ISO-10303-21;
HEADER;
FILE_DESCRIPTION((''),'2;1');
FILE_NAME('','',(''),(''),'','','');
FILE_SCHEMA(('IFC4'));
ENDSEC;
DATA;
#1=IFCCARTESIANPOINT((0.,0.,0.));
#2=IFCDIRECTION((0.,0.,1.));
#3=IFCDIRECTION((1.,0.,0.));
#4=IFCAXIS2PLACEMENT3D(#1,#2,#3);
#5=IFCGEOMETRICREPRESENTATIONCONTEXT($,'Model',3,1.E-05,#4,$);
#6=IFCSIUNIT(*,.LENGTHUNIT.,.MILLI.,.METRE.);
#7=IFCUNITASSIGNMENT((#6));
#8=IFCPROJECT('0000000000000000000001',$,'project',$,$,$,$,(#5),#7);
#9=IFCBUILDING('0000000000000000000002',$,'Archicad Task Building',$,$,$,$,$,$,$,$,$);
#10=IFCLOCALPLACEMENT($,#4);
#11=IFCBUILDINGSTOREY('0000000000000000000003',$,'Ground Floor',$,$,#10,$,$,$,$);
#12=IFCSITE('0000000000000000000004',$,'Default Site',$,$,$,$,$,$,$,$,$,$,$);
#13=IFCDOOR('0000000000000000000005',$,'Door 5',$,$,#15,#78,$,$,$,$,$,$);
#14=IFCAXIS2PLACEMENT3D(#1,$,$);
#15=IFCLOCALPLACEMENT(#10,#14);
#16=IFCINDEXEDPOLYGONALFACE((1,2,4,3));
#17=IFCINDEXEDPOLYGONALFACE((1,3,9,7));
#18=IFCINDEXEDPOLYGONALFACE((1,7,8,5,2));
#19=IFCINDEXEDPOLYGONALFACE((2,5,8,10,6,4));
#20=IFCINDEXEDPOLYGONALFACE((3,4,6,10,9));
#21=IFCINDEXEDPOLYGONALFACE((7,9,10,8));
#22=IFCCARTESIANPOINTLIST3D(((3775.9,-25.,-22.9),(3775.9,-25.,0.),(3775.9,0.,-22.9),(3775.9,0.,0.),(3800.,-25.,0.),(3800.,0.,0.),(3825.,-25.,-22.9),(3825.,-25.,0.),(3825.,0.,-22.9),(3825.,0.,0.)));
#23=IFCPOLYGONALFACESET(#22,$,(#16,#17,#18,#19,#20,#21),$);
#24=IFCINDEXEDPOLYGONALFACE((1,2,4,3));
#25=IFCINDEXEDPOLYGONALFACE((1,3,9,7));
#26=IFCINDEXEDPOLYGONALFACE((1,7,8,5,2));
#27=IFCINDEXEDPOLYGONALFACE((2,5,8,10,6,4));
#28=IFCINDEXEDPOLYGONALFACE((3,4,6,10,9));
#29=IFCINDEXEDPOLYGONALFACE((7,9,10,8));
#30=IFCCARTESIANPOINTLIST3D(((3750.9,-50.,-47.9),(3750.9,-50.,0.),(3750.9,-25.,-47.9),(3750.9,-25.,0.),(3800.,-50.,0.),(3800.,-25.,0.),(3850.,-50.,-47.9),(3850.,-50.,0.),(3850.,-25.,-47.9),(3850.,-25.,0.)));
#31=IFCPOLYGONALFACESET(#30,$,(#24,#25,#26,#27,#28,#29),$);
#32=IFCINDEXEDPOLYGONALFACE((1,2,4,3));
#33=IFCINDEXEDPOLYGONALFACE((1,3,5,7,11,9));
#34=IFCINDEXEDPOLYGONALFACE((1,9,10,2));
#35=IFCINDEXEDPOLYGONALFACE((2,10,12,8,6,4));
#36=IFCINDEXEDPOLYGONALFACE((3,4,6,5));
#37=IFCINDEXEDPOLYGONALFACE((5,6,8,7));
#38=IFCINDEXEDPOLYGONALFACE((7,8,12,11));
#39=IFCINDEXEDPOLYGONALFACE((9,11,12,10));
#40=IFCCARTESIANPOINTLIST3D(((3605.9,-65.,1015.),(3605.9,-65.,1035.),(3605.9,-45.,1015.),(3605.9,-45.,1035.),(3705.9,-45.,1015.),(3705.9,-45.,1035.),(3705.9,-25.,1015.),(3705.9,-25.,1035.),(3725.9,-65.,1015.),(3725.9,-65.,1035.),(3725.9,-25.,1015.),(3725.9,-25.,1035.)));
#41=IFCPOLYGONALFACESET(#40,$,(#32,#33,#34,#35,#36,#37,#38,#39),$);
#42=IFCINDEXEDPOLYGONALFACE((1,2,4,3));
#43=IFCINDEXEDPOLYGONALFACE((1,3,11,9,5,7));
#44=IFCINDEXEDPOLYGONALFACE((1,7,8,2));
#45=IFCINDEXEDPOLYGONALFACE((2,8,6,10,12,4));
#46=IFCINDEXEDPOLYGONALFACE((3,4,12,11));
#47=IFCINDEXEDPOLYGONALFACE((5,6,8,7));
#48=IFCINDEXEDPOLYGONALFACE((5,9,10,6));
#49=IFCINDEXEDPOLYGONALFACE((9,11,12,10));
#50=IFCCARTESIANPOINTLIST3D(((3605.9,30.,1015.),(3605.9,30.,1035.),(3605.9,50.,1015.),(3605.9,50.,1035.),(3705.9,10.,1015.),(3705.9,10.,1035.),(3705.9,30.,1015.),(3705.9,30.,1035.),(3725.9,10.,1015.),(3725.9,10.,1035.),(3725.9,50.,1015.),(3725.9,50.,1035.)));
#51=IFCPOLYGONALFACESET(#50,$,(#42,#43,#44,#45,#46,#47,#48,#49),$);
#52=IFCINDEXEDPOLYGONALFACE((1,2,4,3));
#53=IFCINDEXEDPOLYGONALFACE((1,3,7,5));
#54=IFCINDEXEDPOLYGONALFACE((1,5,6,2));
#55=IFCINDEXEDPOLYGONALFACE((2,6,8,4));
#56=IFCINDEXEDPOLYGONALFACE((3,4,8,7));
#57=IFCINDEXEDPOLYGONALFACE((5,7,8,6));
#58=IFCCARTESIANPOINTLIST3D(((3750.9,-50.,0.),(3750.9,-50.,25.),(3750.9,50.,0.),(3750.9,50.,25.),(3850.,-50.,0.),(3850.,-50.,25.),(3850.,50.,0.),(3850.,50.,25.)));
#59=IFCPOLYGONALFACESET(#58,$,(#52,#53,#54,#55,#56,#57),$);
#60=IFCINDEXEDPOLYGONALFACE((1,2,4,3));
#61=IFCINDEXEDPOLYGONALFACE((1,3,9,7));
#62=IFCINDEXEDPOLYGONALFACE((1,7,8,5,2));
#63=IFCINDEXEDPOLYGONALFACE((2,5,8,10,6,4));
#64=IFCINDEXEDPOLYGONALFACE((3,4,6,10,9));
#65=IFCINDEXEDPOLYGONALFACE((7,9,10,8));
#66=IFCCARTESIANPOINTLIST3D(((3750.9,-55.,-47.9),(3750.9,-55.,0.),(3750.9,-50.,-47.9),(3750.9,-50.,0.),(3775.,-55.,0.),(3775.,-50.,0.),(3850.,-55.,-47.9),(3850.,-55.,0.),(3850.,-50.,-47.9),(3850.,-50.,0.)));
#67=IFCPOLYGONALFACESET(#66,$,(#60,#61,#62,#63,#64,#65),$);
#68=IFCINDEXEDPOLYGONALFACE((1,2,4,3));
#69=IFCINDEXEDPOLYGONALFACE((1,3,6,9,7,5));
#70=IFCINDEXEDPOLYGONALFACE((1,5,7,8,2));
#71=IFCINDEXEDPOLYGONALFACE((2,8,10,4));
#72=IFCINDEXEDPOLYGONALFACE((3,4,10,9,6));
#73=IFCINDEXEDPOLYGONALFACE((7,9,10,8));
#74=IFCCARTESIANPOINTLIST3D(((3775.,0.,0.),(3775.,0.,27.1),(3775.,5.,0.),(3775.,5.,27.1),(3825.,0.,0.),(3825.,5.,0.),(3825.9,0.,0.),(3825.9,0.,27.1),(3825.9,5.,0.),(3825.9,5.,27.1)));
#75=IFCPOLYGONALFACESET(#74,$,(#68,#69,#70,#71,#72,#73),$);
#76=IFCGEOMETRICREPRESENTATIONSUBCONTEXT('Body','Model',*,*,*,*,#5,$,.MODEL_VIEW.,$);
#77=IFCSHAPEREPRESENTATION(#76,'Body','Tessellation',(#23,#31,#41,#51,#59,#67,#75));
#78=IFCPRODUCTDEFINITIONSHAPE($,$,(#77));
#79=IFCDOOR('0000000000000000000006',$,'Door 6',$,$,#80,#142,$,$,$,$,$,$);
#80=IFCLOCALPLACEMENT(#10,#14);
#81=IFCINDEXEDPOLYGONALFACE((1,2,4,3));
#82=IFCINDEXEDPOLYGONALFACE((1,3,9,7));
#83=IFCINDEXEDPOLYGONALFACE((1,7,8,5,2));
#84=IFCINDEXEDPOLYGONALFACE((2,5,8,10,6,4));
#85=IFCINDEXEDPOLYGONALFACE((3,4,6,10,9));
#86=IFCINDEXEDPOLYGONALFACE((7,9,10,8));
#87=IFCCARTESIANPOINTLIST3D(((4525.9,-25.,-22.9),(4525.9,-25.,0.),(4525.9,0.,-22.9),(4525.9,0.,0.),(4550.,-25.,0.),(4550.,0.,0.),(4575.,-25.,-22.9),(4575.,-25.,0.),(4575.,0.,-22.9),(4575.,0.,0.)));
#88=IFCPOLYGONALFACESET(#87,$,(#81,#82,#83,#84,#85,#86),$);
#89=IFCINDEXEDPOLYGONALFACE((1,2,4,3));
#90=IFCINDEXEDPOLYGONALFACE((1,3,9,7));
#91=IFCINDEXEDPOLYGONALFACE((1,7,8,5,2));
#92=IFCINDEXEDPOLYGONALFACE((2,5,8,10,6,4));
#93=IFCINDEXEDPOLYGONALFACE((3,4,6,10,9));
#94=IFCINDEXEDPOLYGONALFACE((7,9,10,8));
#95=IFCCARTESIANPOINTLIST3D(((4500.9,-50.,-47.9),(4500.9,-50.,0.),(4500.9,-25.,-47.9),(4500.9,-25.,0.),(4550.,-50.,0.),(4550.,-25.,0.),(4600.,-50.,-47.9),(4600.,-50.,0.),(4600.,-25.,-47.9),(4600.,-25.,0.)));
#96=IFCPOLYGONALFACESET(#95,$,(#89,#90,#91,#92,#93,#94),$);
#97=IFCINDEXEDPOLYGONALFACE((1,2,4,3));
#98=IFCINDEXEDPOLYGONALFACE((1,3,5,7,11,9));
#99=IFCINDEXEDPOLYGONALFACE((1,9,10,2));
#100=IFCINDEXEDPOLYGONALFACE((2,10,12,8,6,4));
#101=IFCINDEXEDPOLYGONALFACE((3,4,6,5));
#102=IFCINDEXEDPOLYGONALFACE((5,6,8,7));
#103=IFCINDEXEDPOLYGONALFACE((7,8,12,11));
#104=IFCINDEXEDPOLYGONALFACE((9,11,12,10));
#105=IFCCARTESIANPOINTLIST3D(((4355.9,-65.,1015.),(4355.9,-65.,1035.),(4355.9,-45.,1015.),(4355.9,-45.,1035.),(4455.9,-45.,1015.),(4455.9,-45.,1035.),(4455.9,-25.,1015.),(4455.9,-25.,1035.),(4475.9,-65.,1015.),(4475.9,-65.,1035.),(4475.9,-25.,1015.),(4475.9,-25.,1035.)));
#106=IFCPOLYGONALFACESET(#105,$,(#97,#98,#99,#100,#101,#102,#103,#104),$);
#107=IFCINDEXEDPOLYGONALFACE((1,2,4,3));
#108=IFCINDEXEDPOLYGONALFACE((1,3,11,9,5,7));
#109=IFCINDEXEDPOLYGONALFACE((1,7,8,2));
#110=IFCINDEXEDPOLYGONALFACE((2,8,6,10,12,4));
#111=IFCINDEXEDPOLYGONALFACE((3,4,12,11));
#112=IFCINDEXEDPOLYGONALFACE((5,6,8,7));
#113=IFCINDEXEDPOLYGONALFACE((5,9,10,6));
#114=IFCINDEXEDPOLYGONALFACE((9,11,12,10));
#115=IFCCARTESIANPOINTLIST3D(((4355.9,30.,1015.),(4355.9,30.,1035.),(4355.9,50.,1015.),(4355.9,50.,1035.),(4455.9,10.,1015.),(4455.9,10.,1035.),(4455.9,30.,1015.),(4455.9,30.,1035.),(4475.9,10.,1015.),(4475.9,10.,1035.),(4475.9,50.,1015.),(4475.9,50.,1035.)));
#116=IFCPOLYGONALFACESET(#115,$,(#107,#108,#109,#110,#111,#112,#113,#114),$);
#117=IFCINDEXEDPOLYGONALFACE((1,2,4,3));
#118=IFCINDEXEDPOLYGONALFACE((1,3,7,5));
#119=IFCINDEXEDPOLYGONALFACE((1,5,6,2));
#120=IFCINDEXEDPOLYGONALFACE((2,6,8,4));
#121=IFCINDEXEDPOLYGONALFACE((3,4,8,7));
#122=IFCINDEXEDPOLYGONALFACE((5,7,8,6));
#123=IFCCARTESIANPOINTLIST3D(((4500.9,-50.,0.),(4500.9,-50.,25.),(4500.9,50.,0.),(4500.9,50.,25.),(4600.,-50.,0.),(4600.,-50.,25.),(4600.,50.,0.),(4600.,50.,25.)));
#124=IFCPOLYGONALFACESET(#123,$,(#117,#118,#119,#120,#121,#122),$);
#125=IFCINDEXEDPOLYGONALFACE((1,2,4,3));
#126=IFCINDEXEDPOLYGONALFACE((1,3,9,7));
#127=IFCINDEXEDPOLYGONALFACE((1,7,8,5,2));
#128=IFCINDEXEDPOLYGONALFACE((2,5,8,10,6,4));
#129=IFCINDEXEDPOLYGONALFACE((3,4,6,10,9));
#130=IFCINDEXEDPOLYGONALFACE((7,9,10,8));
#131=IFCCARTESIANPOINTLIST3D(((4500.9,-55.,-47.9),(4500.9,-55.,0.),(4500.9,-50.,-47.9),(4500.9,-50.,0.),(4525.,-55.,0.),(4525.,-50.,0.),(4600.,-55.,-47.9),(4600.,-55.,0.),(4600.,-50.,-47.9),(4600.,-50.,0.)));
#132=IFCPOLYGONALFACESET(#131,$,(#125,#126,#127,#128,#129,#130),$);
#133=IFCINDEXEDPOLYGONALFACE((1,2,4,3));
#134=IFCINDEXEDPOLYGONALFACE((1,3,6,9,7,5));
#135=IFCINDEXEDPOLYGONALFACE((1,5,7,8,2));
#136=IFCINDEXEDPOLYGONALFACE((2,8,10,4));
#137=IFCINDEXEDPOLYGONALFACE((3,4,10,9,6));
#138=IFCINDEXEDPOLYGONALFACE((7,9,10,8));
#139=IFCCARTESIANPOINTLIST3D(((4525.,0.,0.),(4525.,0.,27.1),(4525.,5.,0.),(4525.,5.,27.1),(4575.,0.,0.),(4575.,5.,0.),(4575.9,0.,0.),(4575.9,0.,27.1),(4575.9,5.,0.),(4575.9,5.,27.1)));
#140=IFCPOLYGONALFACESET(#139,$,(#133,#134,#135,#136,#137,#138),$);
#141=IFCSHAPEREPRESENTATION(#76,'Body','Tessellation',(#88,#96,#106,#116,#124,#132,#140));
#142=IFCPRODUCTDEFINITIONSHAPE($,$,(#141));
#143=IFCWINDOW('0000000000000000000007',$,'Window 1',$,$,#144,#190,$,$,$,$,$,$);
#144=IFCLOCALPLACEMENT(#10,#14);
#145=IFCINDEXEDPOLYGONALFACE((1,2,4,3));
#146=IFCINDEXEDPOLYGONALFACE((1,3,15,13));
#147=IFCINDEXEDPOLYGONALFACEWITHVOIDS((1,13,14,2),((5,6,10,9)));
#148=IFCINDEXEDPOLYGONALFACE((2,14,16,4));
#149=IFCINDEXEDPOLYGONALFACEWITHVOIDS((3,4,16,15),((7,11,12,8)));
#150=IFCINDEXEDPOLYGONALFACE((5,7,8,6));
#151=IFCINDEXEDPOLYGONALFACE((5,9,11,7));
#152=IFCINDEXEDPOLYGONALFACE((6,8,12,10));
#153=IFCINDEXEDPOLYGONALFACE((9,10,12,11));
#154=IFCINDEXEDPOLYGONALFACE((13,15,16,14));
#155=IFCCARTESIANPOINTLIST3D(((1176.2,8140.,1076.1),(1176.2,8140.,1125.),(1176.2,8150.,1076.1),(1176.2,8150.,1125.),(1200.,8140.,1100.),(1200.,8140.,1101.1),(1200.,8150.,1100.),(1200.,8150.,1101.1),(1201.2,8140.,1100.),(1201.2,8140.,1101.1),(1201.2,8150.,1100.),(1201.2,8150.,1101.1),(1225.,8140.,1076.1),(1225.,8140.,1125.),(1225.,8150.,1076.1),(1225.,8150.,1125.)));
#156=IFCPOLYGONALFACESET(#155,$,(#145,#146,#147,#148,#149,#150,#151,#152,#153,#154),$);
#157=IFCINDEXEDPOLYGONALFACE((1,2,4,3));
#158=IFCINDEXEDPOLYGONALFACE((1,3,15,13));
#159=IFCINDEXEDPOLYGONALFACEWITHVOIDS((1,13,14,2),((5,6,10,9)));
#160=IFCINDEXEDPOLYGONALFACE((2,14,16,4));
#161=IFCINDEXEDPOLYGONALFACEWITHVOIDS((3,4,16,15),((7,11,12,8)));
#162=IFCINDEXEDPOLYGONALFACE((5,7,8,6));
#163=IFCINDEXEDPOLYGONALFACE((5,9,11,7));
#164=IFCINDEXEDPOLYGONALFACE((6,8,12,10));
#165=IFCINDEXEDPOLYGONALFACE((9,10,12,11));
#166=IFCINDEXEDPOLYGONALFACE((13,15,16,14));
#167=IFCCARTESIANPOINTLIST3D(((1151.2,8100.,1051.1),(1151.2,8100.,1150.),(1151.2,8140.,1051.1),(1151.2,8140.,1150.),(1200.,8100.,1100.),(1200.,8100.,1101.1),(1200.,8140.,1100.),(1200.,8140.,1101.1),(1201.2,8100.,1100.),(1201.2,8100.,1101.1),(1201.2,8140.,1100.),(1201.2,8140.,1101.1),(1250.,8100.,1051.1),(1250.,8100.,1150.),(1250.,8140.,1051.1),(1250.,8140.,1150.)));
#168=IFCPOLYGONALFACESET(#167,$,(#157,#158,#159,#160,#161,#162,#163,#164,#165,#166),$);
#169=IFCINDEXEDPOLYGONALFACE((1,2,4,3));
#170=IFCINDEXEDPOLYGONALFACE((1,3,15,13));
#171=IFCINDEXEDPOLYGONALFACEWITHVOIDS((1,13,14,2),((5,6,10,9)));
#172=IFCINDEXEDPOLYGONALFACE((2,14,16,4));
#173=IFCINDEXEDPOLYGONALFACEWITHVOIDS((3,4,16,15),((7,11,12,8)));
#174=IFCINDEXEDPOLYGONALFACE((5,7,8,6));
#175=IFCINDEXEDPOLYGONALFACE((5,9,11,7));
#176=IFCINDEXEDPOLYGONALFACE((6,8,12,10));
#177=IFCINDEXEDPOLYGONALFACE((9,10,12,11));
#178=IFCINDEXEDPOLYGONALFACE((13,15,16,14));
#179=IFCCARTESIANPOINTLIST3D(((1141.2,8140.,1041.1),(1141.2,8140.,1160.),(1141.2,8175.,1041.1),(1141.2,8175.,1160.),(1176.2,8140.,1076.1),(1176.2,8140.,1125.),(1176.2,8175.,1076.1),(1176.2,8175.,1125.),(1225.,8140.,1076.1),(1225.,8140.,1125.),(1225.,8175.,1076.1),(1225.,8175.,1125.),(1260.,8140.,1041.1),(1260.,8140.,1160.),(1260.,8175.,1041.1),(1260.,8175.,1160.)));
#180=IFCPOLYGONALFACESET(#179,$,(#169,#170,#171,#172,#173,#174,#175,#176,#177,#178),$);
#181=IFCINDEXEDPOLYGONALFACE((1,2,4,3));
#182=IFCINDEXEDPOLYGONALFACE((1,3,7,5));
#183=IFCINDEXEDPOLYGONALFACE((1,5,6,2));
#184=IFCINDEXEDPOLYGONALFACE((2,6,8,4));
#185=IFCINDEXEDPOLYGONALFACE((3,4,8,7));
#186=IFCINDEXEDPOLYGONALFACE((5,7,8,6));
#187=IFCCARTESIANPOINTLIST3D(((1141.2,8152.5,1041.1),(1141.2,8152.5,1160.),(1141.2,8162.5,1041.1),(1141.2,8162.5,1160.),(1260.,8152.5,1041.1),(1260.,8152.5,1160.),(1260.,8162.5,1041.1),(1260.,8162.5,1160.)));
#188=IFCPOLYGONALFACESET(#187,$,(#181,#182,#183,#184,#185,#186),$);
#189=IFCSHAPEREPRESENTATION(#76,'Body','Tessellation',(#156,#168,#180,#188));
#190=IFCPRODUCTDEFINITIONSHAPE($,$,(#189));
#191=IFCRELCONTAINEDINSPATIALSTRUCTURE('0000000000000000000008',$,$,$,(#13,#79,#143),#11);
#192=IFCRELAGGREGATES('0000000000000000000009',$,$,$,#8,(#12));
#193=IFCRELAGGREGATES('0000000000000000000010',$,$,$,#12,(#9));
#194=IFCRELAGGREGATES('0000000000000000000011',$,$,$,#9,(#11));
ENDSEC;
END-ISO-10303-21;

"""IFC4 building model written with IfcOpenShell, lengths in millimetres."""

from ifc_helpers import new_model, si_unit, frame, origin_with_axes, place, context, subcontext, project, spatial, line, indexed_curve, outline, extrude, element, save


model = new_model("IFC4")

# Units and contexts
model_context = context("Model", 3, precision=1e-05, world=origin_with_axes())
body_context = subcontext(model_context, "Body", "Model", "MODEL_VIEW")
ifc_project = project(units=[si_unit("LENGTHUNIT", "METRE", prefix="MILLI")], contexts=[model_context])

# Site, building, storey
site = spatial("IfcSite", under=ifc_project, Name="Default Site")
building = spatial("IfcBuilding", under=site, Name="Archicad Task Building")
storey_placement = place(None, origin_with_axes())
storey = spatial("IfcBuildingStorey", under=building, at=storey_placement, Name="Ground Floor")

# Doors
door_1_placement = place(storey_placement, frame((3800.0, -50.0, 0.0), z_axis=(0.0, 0.0, 1.0), x_axis=(1.0, 0.0, 0.0)))
element("IfcDoor", 1, at=door_1_placement, inside=storey, Name="Door 5", context=body_context, shape_type="SweptSolid", body=[
    extrude(outline(indexed_curve([(0.0, 0.0), (0.0, 2.1), (0.9, 2.1), (0.9, 0.0), (-24.1, 0.0), (-24.1, -22.9), (25.0, -22.9), (25.0, 0.0)], segments=[line(1, 2, 3, 4, 5, 6, 7, 8, 1)])), frame((0.0, 25.0, 0.0), z_axis=(0.0, -1.0, 0.0), x_axis=(1.0, 0.0, 0.0)), (0.0, 0.0, -1.0), 25.0),
    extrude(outline(indexed_curve([(0.0, 0.0), (0.0, 2.1), (0.9, 2.1), (0.9, 0.0), (-49.1, 0.0), (-49.1, -47.9), (50.0, -47.9), (50.0, 0.0)], segments=[line(1, 2, 3, 4, 5, 6, 7, 8, 1)])), frame((0.0, 0.0, 0.0), z_axis=(0.0, -1.0, 0.0), x_axis=(1.0, 0.0, 0.0)), (0.0, 0.0, -1.0), 25.0),
    extrude(outline(indexed_curve([(0.0, 0.0), (-49.1, 0.0), (-49.1, 35.0), (0.0, 35.0)], segments=[line(1, 2, 3, 4, 1)])), frame((25.0, 25.0, 25.0), z_axis=(0.0, 0.0, 1.0), x_axis=(1.0, 0.0, 0.0)), (0.0, 0.0, 1.0), -47.9),
    extrude(outline(indexed_curve([(0.0, 0.0), (0.0, -40.0), (-120.0, -40.0), (-120.0, -20.0), (-20.0, -20.0), (-20.0, 0.0)], segments=[line(1, 2, 3, 4, 5, 6, 1)])), frame((-74.1, 25.0, 1015.0), z_axis=(0.0, 0.0, 1.0), x_axis=(1.0, 0.0, 0.0)), (0.0, 0.0, 1.0), 20.0),
    extrude(outline(indexed_curve([(0.0, 0.0), (0.0, 40.0), (-120.0, 40.0), (-120.0, 20.0), (-20.0, 20.0), (-20.0, 0.0)], segments=[line(1, 2, 3, 4, 5, 6, 1)])), frame((-74.1, 60.0, 1015.0), z_axis=(0.0, 0.0, 1.0), x_axis=(1.0, 0.0, 0.0)), (0.0, 0.0, 1.0), 20.0),
    extrude(outline(indexed_curve([(0.0, 0.0), (-99.1, 0.0), (-99.1, 100.0), (0.0, 100.0)], segments=[line(1, 2, 3, 4, 1)])), frame((50.0, 0.0, 0.0), z_axis=(0.0, 0.0, 1.0), x_axis=(1.0, 0.0, 0.0)), (0.0, 0.0, 1.0), 25.0),
    extrude(outline(indexed_curve([(0.0, 0.0), (0.0, 27.1), (50.9, 27.1), (50.9, 0.0), (-24.1, 0.0), (-24.1, -47.9), (75.0, -47.9), (75.0, 0.0)], segments=[line(1, 2, 3, 4, 5, 6, 7, 8, 1)])), frame((-25.0, -5.0, 0.0), z_axis=(0.0, -1.0, 0.0), x_axis=(1.0, 0.0, 0.0)), (0.0, 0.0, -1.0), 5.0),
    extrude(outline(indexed_curve([(0.0, 0.0), (0.0, 27.1), (50.9, 27.1), (50.9, 0.0), (0.9, 0.0), (0.9, -22.9), (50.0, -22.9), (50.0, 0.0)], segments=[line(1, 2, 3, 4, 5, 6, 7, 8, 1)])), frame((-25.0, 50.0, 0.0), z_axis=(0.0, -1.0, 0.0), x_axis=(1.0, 0.0, 0.0)), (0.0, 0.0, -1.0), 5.0),
])
door_2_placement = place(storey_placement, frame((4550.0, -50.0, 0.0), z_axis=(0.0, 0.0, 1.0), x_axis=(1.0, 0.0, 0.0)))
element("IfcDoor", 2, at=door_2_placement, inside=storey, Name="Door 6", context=body_context, shape_type="SweptSolid", body=[
    extrude(outline(indexed_curve([(0.0, 0.0), (0.0, 2.1), (0.9, 2.1), (0.9, 0.0), (-24.1, 0.0), (-24.1, -22.9), (25.0, -22.9), (25.0, 0.0)], segments=[line(1, 2, 3, 4, 5, 6, 7, 8, 1)])), frame((0.0, 25.0, 0.0), z_axis=(0.0, -1.0, 0.0), x_axis=(1.0, 0.0, 0.0)), (0.0, 0.0, -1.0), 25.0),
    extrude(outline(indexed_curve([(0.0, 0.0), (0.0, 2.1), (0.9, 2.1), (0.9, 0.0), (-49.1, 0.0), (-49.1, -47.9), (50.0, -47.9), (50.0, 0.0)], segments=[line(1, 2, 3, 4, 5, 6, 7, 8, 1)])), frame((0.0, 0.0, 0.0), z_axis=(0.0, -1.0, 0.0), x_axis=(1.0, 0.0, 0.0)), (0.0, 0.0, -1.0), 25.0),
    extrude(outline(indexed_curve([(0.0, 0.0), (-49.1, 0.0), (-49.1, 35.0), (0.0, 35.0)], segments=[line(1, 2, 3, 4, 1)])), frame((25.0, 25.0, 25.0), z_axis=(0.0, 0.0, 1.0), x_axis=(1.0, 0.0, 0.0)), (0.0, 0.0, 1.0), -47.9),
    extrude(outline(indexed_curve([(0.0, 0.0), (0.0, -40.0), (-120.0, -40.0), (-120.0, -20.0), (-20.0, -20.0), (-20.0, 0.0)], segments=[line(1, 2, 3, 4, 5, 6, 1)])), frame((-74.1, 25.0, 1015.0), z_axis=(0.0, 0.0, 1.0), x_axis=(1.0, 0.0, 0.0)), (0.0, 0.0, 1.0), 20.0),
    extrude(outline(indexed_curve([(0.0, 0.0), (0.0, 40.0), (-120.0, 40.0), (-120.0, 20.0), (-20.0, 20.0), (-20.0, 0.0)], segments=[line(1, 2, 3, 4, 5, 6, 1)])), frame((-74.1, 60.0, 1015.0), z_axis=(0.0, 0.0, 1.0), x_axis=(1.0, 0.0, 0.0)), (0.0, 0.0, 1.0), 20.0),
    extrude(outline(indexed_curve([(0.0, 0.0), (-99.1, 0.0), (-99.1, 100.0), (0.0, 100.0)], segments=[line(1, 2, 3, 4, 1)])), frame((50.0, 0.0, 0.0), z_axis=(0.0, 0.0, 1.0), x_axis=(1.0, 0.0, 0.0)), (0.0, 0.0, 1.0), 25.0),
    extrude(outline(indexed_curve([(0.0, 0.0), (0.0, 27.1), (50.9, 27.1), (50.9, 0.0), (-24.1, 0.0), (-24.1, -47.9), (75.0, -47.9), (75.0, 0.0)], segments=[line(1, 2, 3, 4, 5, 6, 7, 8, 1)])), frame((-25.0, -5.0, 0.0), z_axis=(0.0, -1.0, 0.0), x_axis=(1.0, 0.0, 0.0)), (0.0, 0.0, -1.0), 5.0),
    extrude(outline(indexed_curve([(0.0, 0.0), (0.0, 27.1), (50.9, 27.1), (50.9, 0.0), (0.9, 0.0), (0.9, -22.9), (50.0, -22.9), (50.0, 0.0)], segments=[line(1, 2, 3, 4, 5, 6, 7, 8, 1)])), frame((-25.0, 50.0, 0.0), z_axis=(0.0, -1.0, 0.0), x_axis=(1.0, 0.0, 0.0)), (0.0, 0.0, -1.0), 5.0),
])

# Window
for number, where, z_axis, x_axis, name in (
    (3, (1200.0, 8050.0, 1100.0), (0.0, 0.0, 1.0), (1.0, 0.0, 0.0), "Window 1"),
):
    element("IfcWindow", number, at=place(storey_placement, frame(where, z_axis=z_axis, x_axis=x_axis)), inside=storey, Name=name, context=body_context, shape_type="SweptSolid", body=[
        extrude(outline(indexed_curve([(0.0, 0.0), (1.2, 0.0), (1.2, 1.1), (0.0, 1.1)], segments=[line(1, 2, 3, 4, 1)]), holes=[indexed_curve([(25.0, 25.0), (-23.8, 25.0), (-23.8, -23.9), (25.0, -23.9)], segments=[line(1, 2, 3, 4, 1)])]), frame((0.0, 90.0, 0.0), z_axis=(0.0, -1.0, 0.0), x_axis=(1.0, 0.0, 0.0)), (0.0, 0.0, -1.0), 10.0),
        extrude(outline(indexed_curve([(0.0, 0.0), (1.2, 0.0), (1.2, 1.1), (0.0, 1.1)], segments=[line(1, 2, 3, 4, 1)]), holes=[indexed_curve([(50.0, 50.0), (-48.8, 50.0), (-48.8, -48.9), (50.0, -48.9)], segments=[line(1, 2, 3, 4, 1)])]), frame((0.0, 50.0, 0.0), z_axis=(0.0, -1.0, 0.0), x_axis=(1.0, 0.0, 0.0)), (0.0, 0.0, -1.0), 40.0),
        extrude(outline(indexed_curve([(0.0, 0.0), (-48.8, 0.0), (-48.8, -48.9), (0.0, -48.9)], segments=[line(1, 2, 3, 4, 1)]), holes=[indexed_curve([(35.0, 35.0), (-83.8, 35.0), (-83.8, -83.9), (35.0, -83.9)], segments=[line(1, 2, 3, 4, 1)])]), frame((25.0, 90.0, 25.0), z_axis=(0.0, -1.0, 0.0), x_axis=(1.0, 0.0, 0.0)), (0.0, 0.0, -1.0), 35.0),
        extrude(outline(indexed_curve([(35.0, 35.0), (-83.8, 35.0), (-83.8, -83.9), (35.0, -83.9)], segments=[line(1, 2, 3, 4, 1)])), frame((25.0, 102.5, 25.0), z_axis=(0.0, -1.0, 0.0), x_axis=(1.0, 0.0, 0.0)), (0.0, 0.0, -1.0), 10.0),
    ])

save(model, "model.ifc")
